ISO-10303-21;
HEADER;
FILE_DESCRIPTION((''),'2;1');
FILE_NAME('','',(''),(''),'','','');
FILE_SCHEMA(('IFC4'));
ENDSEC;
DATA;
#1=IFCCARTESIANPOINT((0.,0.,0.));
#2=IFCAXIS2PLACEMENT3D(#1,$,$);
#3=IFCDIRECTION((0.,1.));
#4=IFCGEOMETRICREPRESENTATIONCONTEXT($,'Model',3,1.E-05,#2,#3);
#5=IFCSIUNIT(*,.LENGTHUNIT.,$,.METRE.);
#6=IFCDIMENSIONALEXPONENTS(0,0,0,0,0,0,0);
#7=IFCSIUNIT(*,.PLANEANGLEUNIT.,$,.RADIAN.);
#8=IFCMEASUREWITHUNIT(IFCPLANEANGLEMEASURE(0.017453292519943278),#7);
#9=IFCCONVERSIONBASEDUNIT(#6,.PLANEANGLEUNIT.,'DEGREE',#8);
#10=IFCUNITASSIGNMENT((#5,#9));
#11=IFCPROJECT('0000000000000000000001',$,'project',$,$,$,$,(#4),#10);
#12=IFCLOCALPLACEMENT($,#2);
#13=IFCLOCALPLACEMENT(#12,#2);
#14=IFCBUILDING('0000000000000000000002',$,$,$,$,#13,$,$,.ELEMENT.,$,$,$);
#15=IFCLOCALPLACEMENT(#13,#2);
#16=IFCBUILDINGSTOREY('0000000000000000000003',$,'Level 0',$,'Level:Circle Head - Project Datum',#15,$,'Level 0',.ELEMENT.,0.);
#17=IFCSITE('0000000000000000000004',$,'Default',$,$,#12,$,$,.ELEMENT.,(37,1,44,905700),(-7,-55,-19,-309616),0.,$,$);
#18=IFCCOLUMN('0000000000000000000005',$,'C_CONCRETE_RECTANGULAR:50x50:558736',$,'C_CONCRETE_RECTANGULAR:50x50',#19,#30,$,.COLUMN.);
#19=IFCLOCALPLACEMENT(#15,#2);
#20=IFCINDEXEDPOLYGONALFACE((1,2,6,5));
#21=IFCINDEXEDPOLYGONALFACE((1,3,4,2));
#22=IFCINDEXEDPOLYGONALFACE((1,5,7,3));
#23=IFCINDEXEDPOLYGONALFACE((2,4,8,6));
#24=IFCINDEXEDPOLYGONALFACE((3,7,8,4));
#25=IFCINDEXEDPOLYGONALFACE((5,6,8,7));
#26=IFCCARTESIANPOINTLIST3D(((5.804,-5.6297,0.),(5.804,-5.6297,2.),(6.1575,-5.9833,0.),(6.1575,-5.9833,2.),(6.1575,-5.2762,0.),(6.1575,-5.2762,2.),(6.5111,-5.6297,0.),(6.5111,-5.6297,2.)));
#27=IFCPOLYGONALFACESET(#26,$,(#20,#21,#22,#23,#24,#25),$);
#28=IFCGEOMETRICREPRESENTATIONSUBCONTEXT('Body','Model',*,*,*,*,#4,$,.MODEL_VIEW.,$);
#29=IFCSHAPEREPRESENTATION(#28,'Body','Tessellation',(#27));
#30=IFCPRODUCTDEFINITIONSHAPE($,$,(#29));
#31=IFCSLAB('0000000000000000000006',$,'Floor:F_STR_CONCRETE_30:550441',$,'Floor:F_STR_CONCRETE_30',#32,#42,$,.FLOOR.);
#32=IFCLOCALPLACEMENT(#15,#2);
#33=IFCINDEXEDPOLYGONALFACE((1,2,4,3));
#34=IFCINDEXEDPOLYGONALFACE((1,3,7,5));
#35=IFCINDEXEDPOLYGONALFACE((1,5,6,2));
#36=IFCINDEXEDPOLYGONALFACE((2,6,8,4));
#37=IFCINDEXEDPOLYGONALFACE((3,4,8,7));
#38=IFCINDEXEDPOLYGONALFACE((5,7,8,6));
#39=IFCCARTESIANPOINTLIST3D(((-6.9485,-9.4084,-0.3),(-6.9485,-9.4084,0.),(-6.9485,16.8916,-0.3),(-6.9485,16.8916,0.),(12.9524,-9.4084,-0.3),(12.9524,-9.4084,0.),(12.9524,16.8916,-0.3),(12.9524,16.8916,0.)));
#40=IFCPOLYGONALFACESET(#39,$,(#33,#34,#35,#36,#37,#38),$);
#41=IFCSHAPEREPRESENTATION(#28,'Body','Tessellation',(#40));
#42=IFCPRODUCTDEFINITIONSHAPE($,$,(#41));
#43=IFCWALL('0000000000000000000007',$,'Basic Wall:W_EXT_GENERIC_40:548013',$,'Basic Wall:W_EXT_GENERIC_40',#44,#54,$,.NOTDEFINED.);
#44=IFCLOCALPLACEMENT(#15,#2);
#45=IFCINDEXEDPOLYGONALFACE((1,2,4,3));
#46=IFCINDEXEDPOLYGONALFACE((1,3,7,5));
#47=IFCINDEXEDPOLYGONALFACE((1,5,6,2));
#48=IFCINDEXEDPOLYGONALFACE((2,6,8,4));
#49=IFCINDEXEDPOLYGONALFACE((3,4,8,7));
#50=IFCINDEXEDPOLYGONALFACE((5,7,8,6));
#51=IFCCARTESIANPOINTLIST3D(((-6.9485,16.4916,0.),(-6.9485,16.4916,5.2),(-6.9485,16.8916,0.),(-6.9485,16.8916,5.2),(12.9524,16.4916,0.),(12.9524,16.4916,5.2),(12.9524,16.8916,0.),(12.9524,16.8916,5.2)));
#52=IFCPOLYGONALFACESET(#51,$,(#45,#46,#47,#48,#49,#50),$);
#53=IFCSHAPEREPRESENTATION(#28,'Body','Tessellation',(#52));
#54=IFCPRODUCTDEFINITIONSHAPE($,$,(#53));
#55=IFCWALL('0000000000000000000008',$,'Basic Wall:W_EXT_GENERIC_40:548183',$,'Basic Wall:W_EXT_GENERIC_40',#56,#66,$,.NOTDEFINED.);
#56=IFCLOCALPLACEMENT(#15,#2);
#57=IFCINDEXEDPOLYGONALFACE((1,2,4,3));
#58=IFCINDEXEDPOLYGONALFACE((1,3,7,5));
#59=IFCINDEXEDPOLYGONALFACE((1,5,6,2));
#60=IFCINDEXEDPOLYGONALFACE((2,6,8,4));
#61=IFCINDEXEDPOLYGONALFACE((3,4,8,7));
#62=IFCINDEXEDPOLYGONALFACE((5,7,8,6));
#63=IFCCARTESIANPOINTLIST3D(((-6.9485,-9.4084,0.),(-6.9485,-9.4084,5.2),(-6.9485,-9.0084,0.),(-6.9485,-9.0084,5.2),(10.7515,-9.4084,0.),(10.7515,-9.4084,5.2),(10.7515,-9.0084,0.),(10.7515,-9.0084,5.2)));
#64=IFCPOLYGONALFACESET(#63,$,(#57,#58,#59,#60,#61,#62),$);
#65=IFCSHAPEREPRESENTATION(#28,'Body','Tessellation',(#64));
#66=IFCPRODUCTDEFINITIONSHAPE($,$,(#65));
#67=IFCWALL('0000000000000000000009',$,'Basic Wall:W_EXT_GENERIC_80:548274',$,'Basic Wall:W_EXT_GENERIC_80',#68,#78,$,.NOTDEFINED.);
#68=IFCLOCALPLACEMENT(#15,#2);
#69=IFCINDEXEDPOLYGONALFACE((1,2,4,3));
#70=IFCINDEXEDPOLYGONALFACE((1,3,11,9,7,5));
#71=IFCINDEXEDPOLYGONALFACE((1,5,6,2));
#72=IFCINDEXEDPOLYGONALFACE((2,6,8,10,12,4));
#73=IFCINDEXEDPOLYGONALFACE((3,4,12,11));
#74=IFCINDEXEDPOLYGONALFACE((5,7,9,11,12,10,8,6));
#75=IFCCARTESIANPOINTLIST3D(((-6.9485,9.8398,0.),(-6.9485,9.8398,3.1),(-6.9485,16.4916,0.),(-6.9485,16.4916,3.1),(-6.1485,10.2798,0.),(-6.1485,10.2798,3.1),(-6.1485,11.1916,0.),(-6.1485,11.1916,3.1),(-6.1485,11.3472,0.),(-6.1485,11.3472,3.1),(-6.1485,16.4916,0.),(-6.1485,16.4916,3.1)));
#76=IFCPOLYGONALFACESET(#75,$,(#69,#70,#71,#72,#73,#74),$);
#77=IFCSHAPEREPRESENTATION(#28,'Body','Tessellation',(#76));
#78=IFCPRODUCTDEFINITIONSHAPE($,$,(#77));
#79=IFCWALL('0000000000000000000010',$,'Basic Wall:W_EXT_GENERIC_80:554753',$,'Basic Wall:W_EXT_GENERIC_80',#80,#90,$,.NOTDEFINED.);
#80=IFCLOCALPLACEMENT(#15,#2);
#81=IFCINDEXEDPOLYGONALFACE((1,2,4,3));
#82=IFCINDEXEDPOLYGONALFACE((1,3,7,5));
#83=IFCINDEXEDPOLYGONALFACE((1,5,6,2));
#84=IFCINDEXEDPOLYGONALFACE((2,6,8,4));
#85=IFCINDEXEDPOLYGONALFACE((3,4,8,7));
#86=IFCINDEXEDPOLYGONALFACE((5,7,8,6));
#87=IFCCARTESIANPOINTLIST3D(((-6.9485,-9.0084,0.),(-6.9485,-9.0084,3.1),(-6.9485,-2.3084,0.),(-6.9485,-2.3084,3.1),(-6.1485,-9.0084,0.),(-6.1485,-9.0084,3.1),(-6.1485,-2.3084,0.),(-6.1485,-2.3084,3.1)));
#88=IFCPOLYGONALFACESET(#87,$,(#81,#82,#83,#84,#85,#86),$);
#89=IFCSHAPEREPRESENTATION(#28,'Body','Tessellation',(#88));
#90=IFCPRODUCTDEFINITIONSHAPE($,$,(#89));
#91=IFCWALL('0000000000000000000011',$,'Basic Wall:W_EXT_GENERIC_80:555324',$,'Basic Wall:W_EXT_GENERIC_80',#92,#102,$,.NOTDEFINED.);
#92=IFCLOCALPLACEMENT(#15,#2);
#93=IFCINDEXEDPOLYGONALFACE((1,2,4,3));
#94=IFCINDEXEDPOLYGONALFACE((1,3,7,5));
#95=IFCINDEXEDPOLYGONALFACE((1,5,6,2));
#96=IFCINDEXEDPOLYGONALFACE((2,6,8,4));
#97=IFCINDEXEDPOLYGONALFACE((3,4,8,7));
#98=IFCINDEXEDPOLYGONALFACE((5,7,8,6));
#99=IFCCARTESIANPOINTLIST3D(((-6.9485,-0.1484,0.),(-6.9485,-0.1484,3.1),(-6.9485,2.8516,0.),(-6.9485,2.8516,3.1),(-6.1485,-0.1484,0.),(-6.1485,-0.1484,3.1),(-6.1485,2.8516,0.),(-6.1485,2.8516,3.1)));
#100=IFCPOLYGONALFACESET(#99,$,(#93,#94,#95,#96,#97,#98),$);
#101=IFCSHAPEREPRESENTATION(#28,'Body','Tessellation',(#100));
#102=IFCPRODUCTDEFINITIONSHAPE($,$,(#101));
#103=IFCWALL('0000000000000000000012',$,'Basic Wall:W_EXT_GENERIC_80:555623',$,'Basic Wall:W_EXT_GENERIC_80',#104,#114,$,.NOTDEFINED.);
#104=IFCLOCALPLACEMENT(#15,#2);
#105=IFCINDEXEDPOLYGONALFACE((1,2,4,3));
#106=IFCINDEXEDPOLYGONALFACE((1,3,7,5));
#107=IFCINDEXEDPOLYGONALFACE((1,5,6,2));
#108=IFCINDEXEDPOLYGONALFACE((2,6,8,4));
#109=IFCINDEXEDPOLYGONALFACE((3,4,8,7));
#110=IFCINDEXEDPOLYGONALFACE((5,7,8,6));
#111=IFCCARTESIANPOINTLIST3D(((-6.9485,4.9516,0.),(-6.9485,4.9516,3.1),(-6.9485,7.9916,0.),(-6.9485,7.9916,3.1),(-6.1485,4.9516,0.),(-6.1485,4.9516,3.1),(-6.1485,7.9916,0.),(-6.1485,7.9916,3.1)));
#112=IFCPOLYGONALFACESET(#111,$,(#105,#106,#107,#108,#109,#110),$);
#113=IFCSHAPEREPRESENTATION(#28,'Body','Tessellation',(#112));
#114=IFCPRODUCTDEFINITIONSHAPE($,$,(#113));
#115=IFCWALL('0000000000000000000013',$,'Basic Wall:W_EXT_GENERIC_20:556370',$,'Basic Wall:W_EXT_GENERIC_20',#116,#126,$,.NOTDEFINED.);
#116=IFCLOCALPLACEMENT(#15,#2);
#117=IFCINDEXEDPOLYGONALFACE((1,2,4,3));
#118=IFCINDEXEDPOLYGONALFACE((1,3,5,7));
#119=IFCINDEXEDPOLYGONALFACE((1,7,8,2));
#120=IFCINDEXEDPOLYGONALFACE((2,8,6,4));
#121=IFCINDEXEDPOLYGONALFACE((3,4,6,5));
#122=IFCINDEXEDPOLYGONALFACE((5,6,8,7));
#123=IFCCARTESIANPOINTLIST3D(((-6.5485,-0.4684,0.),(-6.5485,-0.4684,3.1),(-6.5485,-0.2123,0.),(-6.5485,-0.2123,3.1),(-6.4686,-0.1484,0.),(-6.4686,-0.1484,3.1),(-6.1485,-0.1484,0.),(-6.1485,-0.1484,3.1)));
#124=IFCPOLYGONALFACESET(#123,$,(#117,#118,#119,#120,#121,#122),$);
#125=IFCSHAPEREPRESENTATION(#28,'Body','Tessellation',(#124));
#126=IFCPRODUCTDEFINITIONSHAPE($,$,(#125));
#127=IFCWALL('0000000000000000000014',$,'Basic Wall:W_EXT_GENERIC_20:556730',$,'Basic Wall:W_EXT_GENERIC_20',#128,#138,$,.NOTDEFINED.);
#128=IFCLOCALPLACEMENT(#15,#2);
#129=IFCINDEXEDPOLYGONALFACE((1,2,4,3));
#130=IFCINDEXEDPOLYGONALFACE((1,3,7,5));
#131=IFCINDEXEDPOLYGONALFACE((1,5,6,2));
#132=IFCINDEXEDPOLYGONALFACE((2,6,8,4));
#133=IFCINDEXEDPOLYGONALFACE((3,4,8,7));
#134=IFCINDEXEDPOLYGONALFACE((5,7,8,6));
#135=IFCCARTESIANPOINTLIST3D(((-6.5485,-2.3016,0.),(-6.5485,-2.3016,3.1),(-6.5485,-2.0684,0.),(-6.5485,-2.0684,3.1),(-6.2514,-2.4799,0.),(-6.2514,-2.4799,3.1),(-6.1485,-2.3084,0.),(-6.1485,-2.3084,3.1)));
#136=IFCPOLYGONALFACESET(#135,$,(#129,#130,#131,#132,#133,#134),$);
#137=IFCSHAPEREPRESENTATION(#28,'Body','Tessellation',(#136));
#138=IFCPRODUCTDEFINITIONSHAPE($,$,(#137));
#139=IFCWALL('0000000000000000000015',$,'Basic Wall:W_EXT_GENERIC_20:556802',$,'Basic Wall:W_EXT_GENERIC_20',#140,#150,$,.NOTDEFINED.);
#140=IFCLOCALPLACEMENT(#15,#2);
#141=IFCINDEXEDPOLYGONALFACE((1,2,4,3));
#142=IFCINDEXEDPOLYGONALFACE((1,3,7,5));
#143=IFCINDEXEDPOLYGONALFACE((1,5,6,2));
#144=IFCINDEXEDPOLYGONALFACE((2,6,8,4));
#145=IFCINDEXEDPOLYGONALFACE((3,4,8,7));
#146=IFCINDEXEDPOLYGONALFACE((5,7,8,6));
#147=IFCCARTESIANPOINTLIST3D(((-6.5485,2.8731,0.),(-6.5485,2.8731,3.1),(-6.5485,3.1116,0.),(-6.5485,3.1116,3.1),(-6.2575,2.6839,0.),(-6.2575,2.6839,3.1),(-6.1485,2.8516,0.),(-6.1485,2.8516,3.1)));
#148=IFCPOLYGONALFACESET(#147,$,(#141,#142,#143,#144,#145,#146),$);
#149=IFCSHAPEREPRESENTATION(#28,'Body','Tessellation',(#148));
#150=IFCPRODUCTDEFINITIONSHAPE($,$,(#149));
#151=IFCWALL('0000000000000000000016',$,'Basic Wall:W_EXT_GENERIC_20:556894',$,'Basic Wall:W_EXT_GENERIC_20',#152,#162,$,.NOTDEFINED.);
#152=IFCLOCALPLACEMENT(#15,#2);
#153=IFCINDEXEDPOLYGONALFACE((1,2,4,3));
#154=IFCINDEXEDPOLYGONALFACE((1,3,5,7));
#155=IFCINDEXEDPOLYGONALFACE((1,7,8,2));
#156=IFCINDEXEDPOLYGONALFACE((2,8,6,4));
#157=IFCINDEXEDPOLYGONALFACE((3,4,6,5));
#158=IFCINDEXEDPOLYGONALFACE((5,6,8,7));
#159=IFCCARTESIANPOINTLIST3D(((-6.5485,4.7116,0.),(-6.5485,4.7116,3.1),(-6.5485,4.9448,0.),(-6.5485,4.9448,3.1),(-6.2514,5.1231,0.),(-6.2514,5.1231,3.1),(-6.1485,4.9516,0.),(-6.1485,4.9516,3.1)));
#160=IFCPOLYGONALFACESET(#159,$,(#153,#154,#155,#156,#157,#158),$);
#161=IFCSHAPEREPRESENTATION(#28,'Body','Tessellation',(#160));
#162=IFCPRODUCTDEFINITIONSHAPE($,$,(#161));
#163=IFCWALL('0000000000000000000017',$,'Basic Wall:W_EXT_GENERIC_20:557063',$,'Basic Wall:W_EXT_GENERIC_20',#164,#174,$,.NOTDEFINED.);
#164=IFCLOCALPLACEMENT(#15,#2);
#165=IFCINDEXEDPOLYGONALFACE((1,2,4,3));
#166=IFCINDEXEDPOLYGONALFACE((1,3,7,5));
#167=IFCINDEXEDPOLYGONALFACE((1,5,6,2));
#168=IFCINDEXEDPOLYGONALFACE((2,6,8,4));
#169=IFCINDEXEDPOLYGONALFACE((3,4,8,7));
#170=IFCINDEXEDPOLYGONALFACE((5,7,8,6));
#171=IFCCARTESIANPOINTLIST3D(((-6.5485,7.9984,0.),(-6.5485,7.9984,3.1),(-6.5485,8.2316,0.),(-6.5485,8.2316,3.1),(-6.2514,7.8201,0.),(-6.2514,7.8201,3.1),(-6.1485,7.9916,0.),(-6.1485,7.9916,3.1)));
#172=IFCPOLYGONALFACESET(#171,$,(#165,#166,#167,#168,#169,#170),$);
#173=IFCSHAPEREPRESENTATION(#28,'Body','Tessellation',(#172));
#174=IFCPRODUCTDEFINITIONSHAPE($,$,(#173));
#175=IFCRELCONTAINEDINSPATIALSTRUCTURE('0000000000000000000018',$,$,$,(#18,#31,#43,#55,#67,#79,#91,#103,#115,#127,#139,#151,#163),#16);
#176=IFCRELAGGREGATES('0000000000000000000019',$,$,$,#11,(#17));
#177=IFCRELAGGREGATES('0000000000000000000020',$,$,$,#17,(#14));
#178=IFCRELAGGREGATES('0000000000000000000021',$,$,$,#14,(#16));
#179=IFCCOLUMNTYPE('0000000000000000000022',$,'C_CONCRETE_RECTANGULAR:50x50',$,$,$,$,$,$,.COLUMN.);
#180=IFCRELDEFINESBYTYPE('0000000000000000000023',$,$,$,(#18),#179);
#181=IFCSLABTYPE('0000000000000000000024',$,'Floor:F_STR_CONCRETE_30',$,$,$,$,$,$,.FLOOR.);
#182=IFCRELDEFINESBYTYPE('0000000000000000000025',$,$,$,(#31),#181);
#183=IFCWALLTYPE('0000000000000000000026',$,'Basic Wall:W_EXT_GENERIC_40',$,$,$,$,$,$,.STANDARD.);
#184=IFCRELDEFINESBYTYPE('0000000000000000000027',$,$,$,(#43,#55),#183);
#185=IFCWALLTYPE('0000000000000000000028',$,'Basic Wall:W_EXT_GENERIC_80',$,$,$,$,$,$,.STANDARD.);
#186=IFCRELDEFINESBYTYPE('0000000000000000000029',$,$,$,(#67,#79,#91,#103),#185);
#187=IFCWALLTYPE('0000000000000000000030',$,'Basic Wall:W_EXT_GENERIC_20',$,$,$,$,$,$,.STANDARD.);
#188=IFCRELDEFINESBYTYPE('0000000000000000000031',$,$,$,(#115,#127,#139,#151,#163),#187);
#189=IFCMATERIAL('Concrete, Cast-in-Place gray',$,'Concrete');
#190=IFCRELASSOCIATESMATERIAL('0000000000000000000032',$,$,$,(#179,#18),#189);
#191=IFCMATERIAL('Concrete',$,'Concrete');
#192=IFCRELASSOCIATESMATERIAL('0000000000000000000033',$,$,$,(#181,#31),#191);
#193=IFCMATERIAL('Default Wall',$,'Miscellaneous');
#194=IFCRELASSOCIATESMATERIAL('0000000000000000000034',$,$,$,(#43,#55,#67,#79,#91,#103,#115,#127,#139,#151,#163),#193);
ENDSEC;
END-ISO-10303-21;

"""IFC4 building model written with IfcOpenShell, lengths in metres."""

from ifc_helpers import new_model, entity, si_unit, converted_unit, direction, frame, origin, place, context, subcontext, project, spatial, indexed_curve, outline, extrude, source, transform, mapped, material, type_object, type_shapes, element, save


model = new_model("IFC4")

# Units and contexts
model_context = context("Model", 3, precision=1e-05, world=origin(), true_north=direction((0.0, 1.0)))
body_context = subcontext(model_context, "Body", "Model", "MODEL_VIEW")
ifc_project = project(units=[si_unit("LENGTHUNIT", "METRE"), converted_unit("PLANEANGLEUNIT", "DEGREE", entity("IfcPlaneAngleMeasure", 0.017453292519943278), si_unit("PLANEANGLEUNIT", "RADIAN"), dimensions=[0, 0, 0, 0, 0, 0, 0])], contexts=[model_context])

# Site, building, storey
site_placement = place(None, origin())
site = spatial("IfcSite", under=ifc_project, at=site_placement, Name="Default", CompositionType="ELEMENT", RefLatitude=(37, 1, 44, 905700), RefLongitude=(-7, -55, -19, -309616), RefElevation=0.0)
building_placement = place(site_placement, origin())
building = spatial("IfcBuilding", under=site, at=building_placement, CompositionType="ELEMENT")
storey_placement = place(building_placement, origin())
storey = spatial("IfcBuildingStorey", under=building, at=storey_placement, Name="Level 0", ObjectType="Level:Circle Head - Project Datum", LongName="Level 0", CompositionType="ELEMENT", Elevation=0.0)

# Column
ifc_material_1 = material(Name="Concrete, Cast-in-Place gray", Category="Concrete")
column_type = type_object("IfcColumnType", Name="C_CONCRETE_RECTANGULAR:50x50", PredefinedType="COLUMN", material=ifc_material_1)
shared_shape = source(origin(), body_context, "Body", "SweptSolid", [
    extrude(outline(indexed_curve([(-0.25, -0.25), (0.25, -0.25), (0.25, 0.25), (-0.25, 0.25), (-0.25, -0.25)], self_intersect=False)), frame((0.0, 0.0, 0.0), z_axis=(0.0, 0.0, 1.0), x_axis=(-1.0, 0.0, 0.0)), (0.0, 0.0, 1.0), 2.0),
])
type_shapes(column_type, [shared_shape])
column_placement = place(storey_placement, frame((6.1575, -5.6297, 0.0), z_axis=(0.0, 0.0, 1.0), x_axis=(0.707107, 0.707107, 0.0)))
element("IfcColumn", 1, at=column_placement, inside=storey, type_object=column_type, material=ifc_material_1, Name="C_CONCRETE_RECTANGULAR:50x50:558736", ObjectType="C_CONCRETE_RECTANGULAR:50x50", PredefinedType="COLUMN", context=body_context, shape_type="MappedRepresentation", body=[
    mapped(shared_shape, transform((0.0, 0.0, 0.0), scale=1.0)),
])

# Slab
ifc_material_2 = material(Name="Concrete", Category="Concrete")
slab_type = type_object("IfcSlabType", Name="Floor:F_STR_CONCRETE_30", PredefinedType="FLOOR", material=ifc_material_2)
slab_placement = place(storey_placement, origin())
element("IfcSlab", 2, at=slab_placement, inside=storey, type_object=slab_type, material=ifc_material_2, Name="Floor:F_STR_CONCRETE_30:550441", ObjectType="Floor:F_STR_CONCRETE_30", PredefinedType="FLOOR", context=body_context, shape_type="SweptSolid", body=[
    extrude(outline(indexed_curve([(-13.15, -9.9504), (13.15, -9.9504), (13.15, 9.9504), (-13.15, 9.9504), (-13.15, -9.9504)], self_intersect=False)), frame((3.0019, 3.7416, 0.0), z_axis=(0.0, 0.0, -1.0), x_axis=(0.0, 1.0, 0.0)), (0.0, 0.0, 1.0), 0.3),
])

# Walls
ifc_material_3 = material(Name="Default Wall", Category="Miscellaneous")
wall_type_1 = type_object("IfcWallType", Name="Basic Wall:W_EXT_GENERIC_40", PredefinedType="STANDARD")
wall_1_placement = place(storey_placement, frame((-6.9485, 16.6916, 0.0)))
element("IfcWall", 3, at=wall_1_placement, inside=storey, type_object=wall_type_1, material=ifc_material_3, Name="Basic Wall:W_EXT_GENERIC_40:548013", ObjectType="Basic Wall:W_EXT_GENERIC_40", PredefinedType="NOTDEFINED", context=body_context, shape_type="SweptSolid", body=[
    extrude(outline(indexed_curve([(19.9008, 0.2), (0.0, 0.2), (0.0, -0.2), (19.9008, -0.2), (19.9008, 0.2)], self_intersect=False)), origin(), (0.0, 0.0, 1.0), 5.2),
])
wall_2_placement = place(storey_placement, frame((10.7515, -9.2084, 0.0), z_axis=(0.0, 0.0, 1.0), x_axis=(-1.0, 0.0, 0.0)))
element("IfcWall", 4, at=wall_2_placement, inside=storey, type_object=wall_type_1, material=ifc_material_3, Name="Basic Wall:W_EXT_GENERIC_40:548183", ObjectType="Basic Wall:W_EXT_GENERIC_40", PredefinedType="NOTDEFINED", context=body_context, shape_type="SweptSolid", body=[
    extrude(outline(indexed_curve([(17.7, 0.2), (0.0, 0.2), (0.0, -0.2), (17.7, -0.2), (17.7, 0.2)], self_intersect=False)), origin(), (0.0, 0.0, 1.0), 5.2),
])
wall_type_2 = type_object("IfcWallType", Name="Basic Wall:W_EXT_GENERIC_80", PredefinedType="STANDARD")
wall_3_placement = place(storey_placement, frame((-6.5485, 16.4916, 0.0), z_axis=(0.0, 0.0, 1.0), x_axis=(0.0, -1.0, 0.0)))
element("IfcWall", 5, at=wall_3_placement, inside=storey, type_object=wall_type_2, material=ifc_material_3, Name="Basic Wall:W_EXT_GENERIC_80:548274", ObjectType="Basic Wall:W_EXT_GENERIC_80", PredefinedType="NOTDEFINED", context=body_context, shape_type="SweptSolid", body=[
    extrude(outline(indexed_curve([(6.6517, -0.4), (6.2117, 0.4), (5.3, 0.4), (5.1444, 0.4), (0.0, 0.4), (0.0, -0.4), (6.6517, -0.4)], self_intersect=False)), origin(), (0.0, 0.0, 1.0), 3.1),
])
wall_4_placement = place(storey_placement, frame((-6.5485, -2.3084, 0.0), z_axis=(0.0, 0.0, 1.0), x_axis=(0.0, -1.0, 0.0)))
element("IfcWall", 6, at=wall_4_placement, inside=storey, type_object=wall_type_2, material=ifc_material_3, Name="Basic Wall:W_EXT_GENERIC_80:554753", ObjectType="Basic Wall:W_EXT_GENERIC_80", PredefinedType="NOTDEFINED", context=body_context, shape_type="SweptSolid", body=[
    extrude(outline(indexed_curve([(6.7, 0.4), (0.0, 0.4), (0.0, -0.4), (6.7, -0.4), (6.7, 0.4)], self_intersect=False)), origin(), (0.0, 0.0, 1.0), 3.1),
])
wall_5_placement = place(storey_placement, frame((-6.5485, 2.8516, 0.0), z_axis=(0.0, 0.0, 1.0), x_axis=(0.0, -1.0, 0.0)))
element("IfcWall", 7, at=wall_5_placement, inside=storey, type_object=wall_type_2, material=ifc_material_3, Name="Basic Wall:W_EXT_GENERIC_80:555324", ObjectType="Basic Wall:W_EXT_GENERIC_80", PredefinedType="NOTDEFINED", context=body_context, shape_type="SweptSolid", body=[
    extrude(outline(indexed_curve([(3.0, 0.4), (0.0, 0.4), (0.0, -0.4), (3.0, -0.4), (3.0, 0.4)], self_intersect=False)), origin(), (0.0, 0.0, 1.0), 3.1),
])
wall_6_placement = place(storey_placement, frame((-6.5485, 7.9916, 0.0), z_axis=(0.0, 0.0, 1.0), x_axis=(0.0, -1.0, 0.0)))
element("IfcWall", 8, at=wall_6_placement, inside=storey, type_object=wall_type_2, material=ifc_material_3, Name="Basic Wall:W_EXT_GENERIC_80:555623", ObjectType="Basic Wall:W_EXT_GENERIC_80", PredefinedType="NOTDEFINED", context=body_context, shape_type="SweptSolid", body=[
    extrude(outline(indexed_curve([(3.04, 0.4), (0.0, 0.4), (0.0, -0.4), (3.04, -0.4), (3.04, 0.4)], self_intersect=False)), origin(), (0.0, 0.0, 1.0), 3.1),
])
wall_type_3 = type_object("IfcWallType", Name="Basic Wall:W_EXT_GENERIC_20", PredefinedType="STANDARD")
wall_7_placement = place(storey_placement, frame((-6.2109, -0.0703, 0.0), z_axis=(0.0, 0.0, 1.0), x_axis=(-0.780869, -0.624695, 0.0)))
element("IfcWall", 9, at=wall_7_placement, inside=storey, type_object=wall_type_3, material=ifc_material_3, Name="Basic Wall:W_EXT_GENERIC_20:556370", ObjectType="Basic Wall:W_EXT_GENERIC_20", PredefinedType="NOTDEFINED", context=body_context, shape_type="SweptSolid", body=[
    extrude(outline(indexed_curve([(0.0, 0.1), (0.25, -0.1), (0.3522, -0.1), (0.5122, 0.1), (0.0, 0.1)], self_intersect=False)), origin(), (0.0, 0.0, 1.0), 3.1),
])
wall_8_placement = place(storey_placement, frame((-6.1999, -2.3942, 0.0), z_axis=(0.0, 0.0, 1.0), x_axis=(-0.857493, 0.514496, 0.0)))
element("IfcWall", 10, at=wall_8_placement, inside=storey, type_object=wall_type_3, material=ifc_material_3, Name="Basic Wall:W_EXT_GENERIC_20:556730", ObjectType="Basic Wall:W_EXT_GENERIC_20", PredefinedType="NOTDEFINED", context=body_context, shape_type="SweptSolid", body=[
    extrude(outline(indexed_curve([(0.4665, -0.1), (0.3465, 0.1), (0.0, 0.1), (0.0, -0.1), (0.4665, -0.1)], self_intersect=False)), origin(), (0.0, 0.0, 1.0), 3.1),
])
wall_9_placement = place(storey_placement, frame((-6.203, 2.7677, 0.0), z_axis=(0.0, 0.0, 1.0), x_axis=(-0.838444, 0.544988, 0.0)))
element("IfcWall", 11, at=wall_9_placement, inside=storey, type_object=wall_type_3, material=ifc_material_3, Name="Basic Wall:W_EXT_GENERIC_20:556802", ObjectType="Basic Wall:W_EXT_GENERIC_20", PredefinedType="NOTDEFINED", context=body_context, shape_type="SweptSolid", body=[
    extrude(outline(indexed_curve([(0.4771, -0.1), (0.3471, 0.1), (0.0, 0.1), (0.0, -0.1), (0.4771, -0.1)], self_intersect=False)), origin(), (0.0, 0.0, 1.0), 3.1),
])
wall_10_placement = place(storey_placement, frame((-6.1999, 5.0373, 0.0), z_axis=(0.0, 0.0, 1.0), x_axis=(-0.857493, -0.514496, 0.0)))
element("IfcWall", 12, at=wall_10_placement, inside=storey, type_object=wall_type_3, material=ifc_material_3, Name="Basic Wall:W_EXT_GENERIC_20:556894", ObjectType="Basic Wall:W_EXT_GENERIC_20", PredefinedType="NOTDEFINED", context=body_context, shape_type="SweptSolid", body=[
    extrude(outline(indexed_curve([(0.3465, -0.1), (0.4665, 0.1), (0.0, 0.1), (0.0, -0.1), (0.3465, -0.1)], self_intersect=False)), origin(), (0.0, 0.0, 1.0), 3.1),
])
wall_11_placement = place(storey_placement, frame((-6.1999, 7.9058, 0.0), z_axis=(0.0, 0.0, 1.0), x_axis=(-0.857493, 0.514496, 0.0)))
element("IfcWall", 13, at=wall_11_placement, inside=storey, type_object=wall_type_3, material=ifc_material_3, Name="Basic Wall:W_EXT_GENERIC_20:557063", ObjectType="Basic Wall:W_EXT_GENERIC_20", PredefinedType="NOTDEFINED", context=body_context, shape_type="SweptSolid", body=[
    extrude(outline(indexed_curve([(0.4665, -0.1), (0.3465, 0.1), (0.0, 0.1), (0.0, -0.1), (0.4665, -0.1)], self_intersect=False)), origin(), (0.0, 0.0, 1.0), 3.1),
])

save(model, "model.ifc")
